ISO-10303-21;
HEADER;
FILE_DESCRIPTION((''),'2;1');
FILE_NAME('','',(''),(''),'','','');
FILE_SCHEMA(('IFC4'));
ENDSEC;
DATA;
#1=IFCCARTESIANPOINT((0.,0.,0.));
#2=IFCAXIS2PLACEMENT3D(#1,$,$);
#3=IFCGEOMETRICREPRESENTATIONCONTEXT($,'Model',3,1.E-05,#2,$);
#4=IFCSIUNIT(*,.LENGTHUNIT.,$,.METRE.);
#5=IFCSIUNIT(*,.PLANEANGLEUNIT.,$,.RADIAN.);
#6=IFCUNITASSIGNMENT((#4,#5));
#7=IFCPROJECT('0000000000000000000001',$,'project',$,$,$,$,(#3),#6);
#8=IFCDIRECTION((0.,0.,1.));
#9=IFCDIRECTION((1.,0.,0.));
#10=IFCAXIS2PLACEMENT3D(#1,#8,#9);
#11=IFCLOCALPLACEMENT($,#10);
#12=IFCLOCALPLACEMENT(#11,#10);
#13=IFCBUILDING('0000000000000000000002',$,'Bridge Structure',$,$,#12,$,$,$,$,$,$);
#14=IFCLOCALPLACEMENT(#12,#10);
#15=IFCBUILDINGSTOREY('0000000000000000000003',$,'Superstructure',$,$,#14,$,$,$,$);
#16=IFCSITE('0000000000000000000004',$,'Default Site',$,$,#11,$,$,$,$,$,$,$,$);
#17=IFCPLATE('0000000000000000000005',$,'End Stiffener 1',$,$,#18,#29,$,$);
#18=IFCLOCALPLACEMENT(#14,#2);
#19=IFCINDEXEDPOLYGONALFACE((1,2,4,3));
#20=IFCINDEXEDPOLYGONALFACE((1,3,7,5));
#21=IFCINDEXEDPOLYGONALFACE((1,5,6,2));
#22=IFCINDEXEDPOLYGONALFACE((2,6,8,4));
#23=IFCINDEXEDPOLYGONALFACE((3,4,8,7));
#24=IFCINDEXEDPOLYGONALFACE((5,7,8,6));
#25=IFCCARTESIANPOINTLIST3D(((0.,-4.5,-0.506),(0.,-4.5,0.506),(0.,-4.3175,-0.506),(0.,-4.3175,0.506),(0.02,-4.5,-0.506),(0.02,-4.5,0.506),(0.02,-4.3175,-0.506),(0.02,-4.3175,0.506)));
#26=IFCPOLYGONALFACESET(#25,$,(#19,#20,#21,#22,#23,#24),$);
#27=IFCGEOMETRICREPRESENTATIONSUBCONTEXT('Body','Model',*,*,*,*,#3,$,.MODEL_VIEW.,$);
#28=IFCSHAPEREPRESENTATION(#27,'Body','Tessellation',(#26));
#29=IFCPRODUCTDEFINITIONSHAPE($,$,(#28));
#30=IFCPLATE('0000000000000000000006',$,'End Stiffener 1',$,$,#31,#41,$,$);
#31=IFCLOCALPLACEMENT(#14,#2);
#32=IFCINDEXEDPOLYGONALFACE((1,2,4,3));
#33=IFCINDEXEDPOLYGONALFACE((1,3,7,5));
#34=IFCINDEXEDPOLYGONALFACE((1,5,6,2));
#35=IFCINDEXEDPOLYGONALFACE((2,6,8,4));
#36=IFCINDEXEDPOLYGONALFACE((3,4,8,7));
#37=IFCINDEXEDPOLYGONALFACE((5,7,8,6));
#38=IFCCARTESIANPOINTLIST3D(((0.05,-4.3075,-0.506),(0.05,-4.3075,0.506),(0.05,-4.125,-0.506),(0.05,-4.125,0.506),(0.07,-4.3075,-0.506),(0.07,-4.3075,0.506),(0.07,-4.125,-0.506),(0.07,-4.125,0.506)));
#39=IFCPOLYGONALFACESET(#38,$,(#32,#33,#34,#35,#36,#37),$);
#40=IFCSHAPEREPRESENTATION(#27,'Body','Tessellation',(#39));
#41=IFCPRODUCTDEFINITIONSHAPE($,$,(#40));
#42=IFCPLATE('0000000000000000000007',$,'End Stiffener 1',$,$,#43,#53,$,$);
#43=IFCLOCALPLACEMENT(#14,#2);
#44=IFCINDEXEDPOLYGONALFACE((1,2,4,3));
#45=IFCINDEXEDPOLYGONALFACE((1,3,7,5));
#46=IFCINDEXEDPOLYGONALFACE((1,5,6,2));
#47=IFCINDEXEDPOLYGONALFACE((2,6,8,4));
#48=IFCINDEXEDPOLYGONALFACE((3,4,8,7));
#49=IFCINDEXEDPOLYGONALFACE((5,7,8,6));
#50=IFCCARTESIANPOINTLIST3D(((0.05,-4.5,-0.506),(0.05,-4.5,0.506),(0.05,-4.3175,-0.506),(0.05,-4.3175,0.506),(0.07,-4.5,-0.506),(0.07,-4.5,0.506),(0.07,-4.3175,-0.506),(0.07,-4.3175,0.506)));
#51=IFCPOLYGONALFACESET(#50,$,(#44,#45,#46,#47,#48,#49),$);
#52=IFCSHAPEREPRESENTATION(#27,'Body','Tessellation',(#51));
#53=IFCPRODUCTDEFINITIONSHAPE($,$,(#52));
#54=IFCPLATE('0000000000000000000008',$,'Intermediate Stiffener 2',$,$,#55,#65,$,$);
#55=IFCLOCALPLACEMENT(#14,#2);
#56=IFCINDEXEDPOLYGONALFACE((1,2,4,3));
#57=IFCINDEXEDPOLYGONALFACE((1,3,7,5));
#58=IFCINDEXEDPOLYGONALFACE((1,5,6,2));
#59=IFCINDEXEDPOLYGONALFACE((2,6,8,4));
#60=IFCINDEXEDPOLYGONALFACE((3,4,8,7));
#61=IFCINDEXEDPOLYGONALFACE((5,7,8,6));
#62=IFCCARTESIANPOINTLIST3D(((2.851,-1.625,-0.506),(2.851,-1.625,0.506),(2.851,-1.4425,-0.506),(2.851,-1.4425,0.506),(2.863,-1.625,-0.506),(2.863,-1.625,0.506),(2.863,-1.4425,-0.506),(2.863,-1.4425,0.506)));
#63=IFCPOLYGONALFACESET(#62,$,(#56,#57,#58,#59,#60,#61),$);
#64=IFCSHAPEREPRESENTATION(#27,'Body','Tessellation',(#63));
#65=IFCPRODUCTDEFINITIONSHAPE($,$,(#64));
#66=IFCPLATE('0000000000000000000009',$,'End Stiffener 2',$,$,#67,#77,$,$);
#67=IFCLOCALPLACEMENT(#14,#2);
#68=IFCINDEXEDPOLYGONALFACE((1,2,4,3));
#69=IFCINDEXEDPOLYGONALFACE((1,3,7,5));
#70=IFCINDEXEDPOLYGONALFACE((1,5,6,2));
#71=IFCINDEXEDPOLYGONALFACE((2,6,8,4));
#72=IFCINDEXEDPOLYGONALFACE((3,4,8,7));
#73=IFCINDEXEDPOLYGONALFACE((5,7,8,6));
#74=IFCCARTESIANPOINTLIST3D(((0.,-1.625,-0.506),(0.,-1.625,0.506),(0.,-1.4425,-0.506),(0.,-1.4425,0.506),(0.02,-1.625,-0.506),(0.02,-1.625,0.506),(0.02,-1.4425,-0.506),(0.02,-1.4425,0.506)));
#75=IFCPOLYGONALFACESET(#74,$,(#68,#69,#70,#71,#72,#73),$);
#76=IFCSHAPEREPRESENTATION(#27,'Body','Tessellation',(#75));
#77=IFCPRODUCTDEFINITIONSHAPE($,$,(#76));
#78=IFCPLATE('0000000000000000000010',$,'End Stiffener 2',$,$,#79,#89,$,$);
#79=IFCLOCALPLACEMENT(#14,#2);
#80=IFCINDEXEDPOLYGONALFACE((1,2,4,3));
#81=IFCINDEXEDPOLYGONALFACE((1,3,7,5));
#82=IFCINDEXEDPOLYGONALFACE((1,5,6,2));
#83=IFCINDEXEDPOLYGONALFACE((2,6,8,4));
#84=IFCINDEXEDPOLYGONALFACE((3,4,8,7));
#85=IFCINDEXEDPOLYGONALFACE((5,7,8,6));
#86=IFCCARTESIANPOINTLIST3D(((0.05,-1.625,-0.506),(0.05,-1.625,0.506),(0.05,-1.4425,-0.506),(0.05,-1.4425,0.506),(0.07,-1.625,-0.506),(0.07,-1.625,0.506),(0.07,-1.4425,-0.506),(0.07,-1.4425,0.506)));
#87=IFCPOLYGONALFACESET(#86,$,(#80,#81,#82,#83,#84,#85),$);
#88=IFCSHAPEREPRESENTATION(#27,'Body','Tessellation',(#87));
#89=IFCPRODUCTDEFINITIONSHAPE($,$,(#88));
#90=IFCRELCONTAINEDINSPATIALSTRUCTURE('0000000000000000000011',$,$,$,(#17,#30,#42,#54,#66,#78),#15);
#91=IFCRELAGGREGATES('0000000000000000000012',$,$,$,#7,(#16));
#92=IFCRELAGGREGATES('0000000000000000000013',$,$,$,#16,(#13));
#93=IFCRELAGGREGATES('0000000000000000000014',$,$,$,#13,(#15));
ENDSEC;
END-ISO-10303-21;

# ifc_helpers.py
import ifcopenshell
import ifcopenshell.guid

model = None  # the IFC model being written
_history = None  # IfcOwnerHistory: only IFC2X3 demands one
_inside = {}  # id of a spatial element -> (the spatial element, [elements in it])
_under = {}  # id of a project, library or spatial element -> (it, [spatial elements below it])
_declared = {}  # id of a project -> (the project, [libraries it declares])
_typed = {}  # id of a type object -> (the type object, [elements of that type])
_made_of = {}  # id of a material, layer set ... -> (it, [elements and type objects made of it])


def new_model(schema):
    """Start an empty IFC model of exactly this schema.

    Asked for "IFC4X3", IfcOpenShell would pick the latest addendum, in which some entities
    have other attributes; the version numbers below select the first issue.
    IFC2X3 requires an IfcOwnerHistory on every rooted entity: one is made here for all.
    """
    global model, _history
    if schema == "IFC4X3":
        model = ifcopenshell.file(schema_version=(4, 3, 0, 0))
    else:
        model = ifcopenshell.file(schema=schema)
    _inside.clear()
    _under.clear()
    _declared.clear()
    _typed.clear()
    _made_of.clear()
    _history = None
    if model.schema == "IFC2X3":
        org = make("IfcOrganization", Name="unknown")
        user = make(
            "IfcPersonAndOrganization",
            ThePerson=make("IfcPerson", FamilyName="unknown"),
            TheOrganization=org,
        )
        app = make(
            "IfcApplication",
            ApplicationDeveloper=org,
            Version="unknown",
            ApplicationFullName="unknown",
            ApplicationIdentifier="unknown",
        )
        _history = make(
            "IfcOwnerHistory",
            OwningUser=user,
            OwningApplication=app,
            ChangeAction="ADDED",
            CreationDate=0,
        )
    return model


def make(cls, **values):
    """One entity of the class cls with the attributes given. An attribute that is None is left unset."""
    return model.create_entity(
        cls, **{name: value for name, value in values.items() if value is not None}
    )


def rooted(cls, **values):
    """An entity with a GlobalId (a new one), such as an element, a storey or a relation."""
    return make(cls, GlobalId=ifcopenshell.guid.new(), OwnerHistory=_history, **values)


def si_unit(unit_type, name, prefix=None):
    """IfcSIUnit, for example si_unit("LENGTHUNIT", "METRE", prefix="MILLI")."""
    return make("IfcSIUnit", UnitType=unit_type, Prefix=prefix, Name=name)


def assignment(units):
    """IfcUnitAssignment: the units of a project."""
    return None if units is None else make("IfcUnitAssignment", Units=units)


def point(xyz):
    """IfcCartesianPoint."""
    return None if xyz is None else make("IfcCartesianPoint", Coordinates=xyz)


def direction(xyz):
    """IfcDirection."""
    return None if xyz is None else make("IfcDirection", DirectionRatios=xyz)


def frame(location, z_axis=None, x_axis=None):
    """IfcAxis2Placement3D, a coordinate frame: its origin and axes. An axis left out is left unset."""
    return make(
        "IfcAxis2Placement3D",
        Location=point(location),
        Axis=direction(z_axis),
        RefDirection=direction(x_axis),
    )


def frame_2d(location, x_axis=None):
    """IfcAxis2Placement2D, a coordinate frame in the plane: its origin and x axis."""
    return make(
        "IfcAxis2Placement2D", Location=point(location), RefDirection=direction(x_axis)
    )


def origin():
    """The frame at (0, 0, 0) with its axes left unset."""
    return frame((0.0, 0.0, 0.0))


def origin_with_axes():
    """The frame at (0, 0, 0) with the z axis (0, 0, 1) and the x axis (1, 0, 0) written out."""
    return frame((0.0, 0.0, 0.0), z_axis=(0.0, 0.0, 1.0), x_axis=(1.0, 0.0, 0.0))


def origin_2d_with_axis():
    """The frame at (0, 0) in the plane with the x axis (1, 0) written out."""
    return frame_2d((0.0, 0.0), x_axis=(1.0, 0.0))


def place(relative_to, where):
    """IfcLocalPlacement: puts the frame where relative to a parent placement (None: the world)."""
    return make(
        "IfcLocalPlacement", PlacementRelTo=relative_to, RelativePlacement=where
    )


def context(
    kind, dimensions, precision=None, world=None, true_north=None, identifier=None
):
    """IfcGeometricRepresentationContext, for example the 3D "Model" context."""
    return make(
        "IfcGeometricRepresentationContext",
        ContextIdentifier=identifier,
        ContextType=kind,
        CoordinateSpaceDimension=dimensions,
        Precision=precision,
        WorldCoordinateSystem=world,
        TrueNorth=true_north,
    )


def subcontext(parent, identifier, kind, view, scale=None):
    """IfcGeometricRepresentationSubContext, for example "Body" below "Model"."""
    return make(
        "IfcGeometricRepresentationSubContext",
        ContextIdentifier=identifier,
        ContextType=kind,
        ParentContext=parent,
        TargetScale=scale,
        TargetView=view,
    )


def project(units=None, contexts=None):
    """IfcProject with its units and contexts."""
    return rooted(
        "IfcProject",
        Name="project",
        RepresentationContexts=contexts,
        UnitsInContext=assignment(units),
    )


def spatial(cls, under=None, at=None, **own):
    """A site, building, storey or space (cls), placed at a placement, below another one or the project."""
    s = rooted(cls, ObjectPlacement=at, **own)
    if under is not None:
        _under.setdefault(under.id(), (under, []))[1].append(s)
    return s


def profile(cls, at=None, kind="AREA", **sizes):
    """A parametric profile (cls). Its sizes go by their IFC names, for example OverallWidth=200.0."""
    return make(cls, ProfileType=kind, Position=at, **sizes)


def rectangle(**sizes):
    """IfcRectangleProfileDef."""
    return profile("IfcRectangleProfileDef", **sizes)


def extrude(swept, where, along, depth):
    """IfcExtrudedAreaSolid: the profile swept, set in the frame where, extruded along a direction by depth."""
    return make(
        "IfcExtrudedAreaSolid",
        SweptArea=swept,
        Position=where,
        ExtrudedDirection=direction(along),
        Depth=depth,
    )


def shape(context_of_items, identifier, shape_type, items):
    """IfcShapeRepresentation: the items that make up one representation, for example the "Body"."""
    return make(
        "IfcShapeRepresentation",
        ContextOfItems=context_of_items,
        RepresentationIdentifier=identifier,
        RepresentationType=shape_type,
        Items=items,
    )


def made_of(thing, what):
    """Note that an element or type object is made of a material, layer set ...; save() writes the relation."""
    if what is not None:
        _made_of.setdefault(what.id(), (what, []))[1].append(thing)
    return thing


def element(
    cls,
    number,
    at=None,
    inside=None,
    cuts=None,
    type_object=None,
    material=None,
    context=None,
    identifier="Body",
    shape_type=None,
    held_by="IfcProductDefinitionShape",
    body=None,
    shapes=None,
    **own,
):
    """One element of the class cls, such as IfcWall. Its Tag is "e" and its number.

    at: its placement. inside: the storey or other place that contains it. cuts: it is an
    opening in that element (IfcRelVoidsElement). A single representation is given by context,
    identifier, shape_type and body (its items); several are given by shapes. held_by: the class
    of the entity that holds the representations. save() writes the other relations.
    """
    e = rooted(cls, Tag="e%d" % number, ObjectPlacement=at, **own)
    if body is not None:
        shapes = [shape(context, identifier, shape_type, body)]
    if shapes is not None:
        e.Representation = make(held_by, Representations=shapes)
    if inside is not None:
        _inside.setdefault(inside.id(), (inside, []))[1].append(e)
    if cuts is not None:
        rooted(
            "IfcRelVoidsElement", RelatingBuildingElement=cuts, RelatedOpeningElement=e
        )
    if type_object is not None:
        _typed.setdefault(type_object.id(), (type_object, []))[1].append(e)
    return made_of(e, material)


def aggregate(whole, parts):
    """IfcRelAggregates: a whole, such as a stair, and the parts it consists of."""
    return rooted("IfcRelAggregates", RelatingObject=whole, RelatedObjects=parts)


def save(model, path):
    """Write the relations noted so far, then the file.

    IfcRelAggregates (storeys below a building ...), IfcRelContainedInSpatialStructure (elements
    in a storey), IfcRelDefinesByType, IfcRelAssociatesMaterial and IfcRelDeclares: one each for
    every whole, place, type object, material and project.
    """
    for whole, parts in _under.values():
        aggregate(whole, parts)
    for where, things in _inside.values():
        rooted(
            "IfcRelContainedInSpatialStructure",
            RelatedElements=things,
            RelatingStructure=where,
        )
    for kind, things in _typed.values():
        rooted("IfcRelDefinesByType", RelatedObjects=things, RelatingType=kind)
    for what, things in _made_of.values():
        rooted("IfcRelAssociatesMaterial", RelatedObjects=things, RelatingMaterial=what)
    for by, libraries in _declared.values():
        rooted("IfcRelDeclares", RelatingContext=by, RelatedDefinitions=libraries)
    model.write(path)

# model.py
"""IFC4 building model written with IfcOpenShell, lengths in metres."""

from ifc_helpers import new_model, si_unit, frame, origin, origin_with_axes, origin_2d_with_axis, place, context, subcontext, project, spatial, rectangle, extrude, element, save


model = new_model("IFC4")

# Units and contexts
model_context = context("Model", 3, precision=1e-05, world=origin())
body_context = subcontext(model_context, "Body", "Model", "MODEL_VIEW")
ifc_project = project(units=[si_unit("LENGTHUNIT", "METRE"), si_unit("PLANEANGLEUNIT", "RADIAN")], contexts=[model_context])

# Site, building, storey
site_placement = place(None, origin_with_axes())
site = spatial("IfcSite", under=ifc_project, at=site_placement, Name="Default Site")
building_placement = place(site_placement, origin_with_axes())
building = spatial("IfcBuilding", under=site, at=building_placement, Name="Bridge Structure")
storey_placement = place(building_placement, origin_with_axes())
storey = spatial("IfcBuildingStorey", under=building, at=storey_placement, Name="Superstructure")

# Plates
for number, where, z_axis, x_axis, name in (
    (1, (0.01, -4.4088, -0.506), (0.0, 0.0, 1.0), (1.0, 0.0, 0.0), "End Stiffener 1"),
    (2, (0.06, -4.2163, -0.506), (0.0, 0.0, 1.0), (1.0, 0.0, 0.0), "End Stiffener 1"),
    (3, (0.06, -4.4088, -0.506), (0.0, 0.0, 1.0), (1.0, 0.0, 0.0), "End Stiffener 1"),
):
    element("IfcPlate", number, at=place(storey_placement, frame(where, z_axis=z_axis, x_axis=x_axis)), inside=storey, Name=name, context=body_context, shape_type="SweptSolid", body=[
        extrude(rectangle(XDim=0.02, YDim=0.1825, at=origin_2d_with_axis()), origin_with_axes(), (0.0, 0.0, 1.0), 1.012),
    ])
plate_1_placement = place(storey_placement, frame((2.857, -1.5337, -0.506), z_axis=(0.0, 0.0, 1.0), x_axis=(1.0, 0.0, 0.0)))
element("IfcPlate", 4, at=plate_1_placement, inside=storey, Name="Intermediate Stiffener 2", context=body_context, shape_type="SweptSolid", body=[
    extrude(rectangle(XDim=0.012, YDim=0.1825, at=origin_2d_with_axis()), origin_with_axes(), (0.0, 0.0, 1.0), 1.012),
])
for number, where, z_axis, x_axis, name in (
    (5, (0.01, -1.5337, -0.506), (0.0, 0.0, 1.0), (1.0, 0.0, 0.0), "End Stiffener 2"),
    (6, (0.06, -1.5337, -0.506), (0.0, 0.0, 1.0), (1.0, 0.0, 0.0), "End Stiffener 2"),
):
    element("IfcPlate", number, at=place(storey_placement, frame(where, z_axis=z_axis, x_axis=x_axis)), inside=storey, Name=name, context=body_context, shape_type="SweptSolid", body=[
        extrude(rectangle(XDim=0.02, YDim=0.1825, at=origin_2d_with_axis()), origin_with_axes(), (0.0, 0.0, 1.0), 1.012),
    ])

save(model, "model.ifc")
